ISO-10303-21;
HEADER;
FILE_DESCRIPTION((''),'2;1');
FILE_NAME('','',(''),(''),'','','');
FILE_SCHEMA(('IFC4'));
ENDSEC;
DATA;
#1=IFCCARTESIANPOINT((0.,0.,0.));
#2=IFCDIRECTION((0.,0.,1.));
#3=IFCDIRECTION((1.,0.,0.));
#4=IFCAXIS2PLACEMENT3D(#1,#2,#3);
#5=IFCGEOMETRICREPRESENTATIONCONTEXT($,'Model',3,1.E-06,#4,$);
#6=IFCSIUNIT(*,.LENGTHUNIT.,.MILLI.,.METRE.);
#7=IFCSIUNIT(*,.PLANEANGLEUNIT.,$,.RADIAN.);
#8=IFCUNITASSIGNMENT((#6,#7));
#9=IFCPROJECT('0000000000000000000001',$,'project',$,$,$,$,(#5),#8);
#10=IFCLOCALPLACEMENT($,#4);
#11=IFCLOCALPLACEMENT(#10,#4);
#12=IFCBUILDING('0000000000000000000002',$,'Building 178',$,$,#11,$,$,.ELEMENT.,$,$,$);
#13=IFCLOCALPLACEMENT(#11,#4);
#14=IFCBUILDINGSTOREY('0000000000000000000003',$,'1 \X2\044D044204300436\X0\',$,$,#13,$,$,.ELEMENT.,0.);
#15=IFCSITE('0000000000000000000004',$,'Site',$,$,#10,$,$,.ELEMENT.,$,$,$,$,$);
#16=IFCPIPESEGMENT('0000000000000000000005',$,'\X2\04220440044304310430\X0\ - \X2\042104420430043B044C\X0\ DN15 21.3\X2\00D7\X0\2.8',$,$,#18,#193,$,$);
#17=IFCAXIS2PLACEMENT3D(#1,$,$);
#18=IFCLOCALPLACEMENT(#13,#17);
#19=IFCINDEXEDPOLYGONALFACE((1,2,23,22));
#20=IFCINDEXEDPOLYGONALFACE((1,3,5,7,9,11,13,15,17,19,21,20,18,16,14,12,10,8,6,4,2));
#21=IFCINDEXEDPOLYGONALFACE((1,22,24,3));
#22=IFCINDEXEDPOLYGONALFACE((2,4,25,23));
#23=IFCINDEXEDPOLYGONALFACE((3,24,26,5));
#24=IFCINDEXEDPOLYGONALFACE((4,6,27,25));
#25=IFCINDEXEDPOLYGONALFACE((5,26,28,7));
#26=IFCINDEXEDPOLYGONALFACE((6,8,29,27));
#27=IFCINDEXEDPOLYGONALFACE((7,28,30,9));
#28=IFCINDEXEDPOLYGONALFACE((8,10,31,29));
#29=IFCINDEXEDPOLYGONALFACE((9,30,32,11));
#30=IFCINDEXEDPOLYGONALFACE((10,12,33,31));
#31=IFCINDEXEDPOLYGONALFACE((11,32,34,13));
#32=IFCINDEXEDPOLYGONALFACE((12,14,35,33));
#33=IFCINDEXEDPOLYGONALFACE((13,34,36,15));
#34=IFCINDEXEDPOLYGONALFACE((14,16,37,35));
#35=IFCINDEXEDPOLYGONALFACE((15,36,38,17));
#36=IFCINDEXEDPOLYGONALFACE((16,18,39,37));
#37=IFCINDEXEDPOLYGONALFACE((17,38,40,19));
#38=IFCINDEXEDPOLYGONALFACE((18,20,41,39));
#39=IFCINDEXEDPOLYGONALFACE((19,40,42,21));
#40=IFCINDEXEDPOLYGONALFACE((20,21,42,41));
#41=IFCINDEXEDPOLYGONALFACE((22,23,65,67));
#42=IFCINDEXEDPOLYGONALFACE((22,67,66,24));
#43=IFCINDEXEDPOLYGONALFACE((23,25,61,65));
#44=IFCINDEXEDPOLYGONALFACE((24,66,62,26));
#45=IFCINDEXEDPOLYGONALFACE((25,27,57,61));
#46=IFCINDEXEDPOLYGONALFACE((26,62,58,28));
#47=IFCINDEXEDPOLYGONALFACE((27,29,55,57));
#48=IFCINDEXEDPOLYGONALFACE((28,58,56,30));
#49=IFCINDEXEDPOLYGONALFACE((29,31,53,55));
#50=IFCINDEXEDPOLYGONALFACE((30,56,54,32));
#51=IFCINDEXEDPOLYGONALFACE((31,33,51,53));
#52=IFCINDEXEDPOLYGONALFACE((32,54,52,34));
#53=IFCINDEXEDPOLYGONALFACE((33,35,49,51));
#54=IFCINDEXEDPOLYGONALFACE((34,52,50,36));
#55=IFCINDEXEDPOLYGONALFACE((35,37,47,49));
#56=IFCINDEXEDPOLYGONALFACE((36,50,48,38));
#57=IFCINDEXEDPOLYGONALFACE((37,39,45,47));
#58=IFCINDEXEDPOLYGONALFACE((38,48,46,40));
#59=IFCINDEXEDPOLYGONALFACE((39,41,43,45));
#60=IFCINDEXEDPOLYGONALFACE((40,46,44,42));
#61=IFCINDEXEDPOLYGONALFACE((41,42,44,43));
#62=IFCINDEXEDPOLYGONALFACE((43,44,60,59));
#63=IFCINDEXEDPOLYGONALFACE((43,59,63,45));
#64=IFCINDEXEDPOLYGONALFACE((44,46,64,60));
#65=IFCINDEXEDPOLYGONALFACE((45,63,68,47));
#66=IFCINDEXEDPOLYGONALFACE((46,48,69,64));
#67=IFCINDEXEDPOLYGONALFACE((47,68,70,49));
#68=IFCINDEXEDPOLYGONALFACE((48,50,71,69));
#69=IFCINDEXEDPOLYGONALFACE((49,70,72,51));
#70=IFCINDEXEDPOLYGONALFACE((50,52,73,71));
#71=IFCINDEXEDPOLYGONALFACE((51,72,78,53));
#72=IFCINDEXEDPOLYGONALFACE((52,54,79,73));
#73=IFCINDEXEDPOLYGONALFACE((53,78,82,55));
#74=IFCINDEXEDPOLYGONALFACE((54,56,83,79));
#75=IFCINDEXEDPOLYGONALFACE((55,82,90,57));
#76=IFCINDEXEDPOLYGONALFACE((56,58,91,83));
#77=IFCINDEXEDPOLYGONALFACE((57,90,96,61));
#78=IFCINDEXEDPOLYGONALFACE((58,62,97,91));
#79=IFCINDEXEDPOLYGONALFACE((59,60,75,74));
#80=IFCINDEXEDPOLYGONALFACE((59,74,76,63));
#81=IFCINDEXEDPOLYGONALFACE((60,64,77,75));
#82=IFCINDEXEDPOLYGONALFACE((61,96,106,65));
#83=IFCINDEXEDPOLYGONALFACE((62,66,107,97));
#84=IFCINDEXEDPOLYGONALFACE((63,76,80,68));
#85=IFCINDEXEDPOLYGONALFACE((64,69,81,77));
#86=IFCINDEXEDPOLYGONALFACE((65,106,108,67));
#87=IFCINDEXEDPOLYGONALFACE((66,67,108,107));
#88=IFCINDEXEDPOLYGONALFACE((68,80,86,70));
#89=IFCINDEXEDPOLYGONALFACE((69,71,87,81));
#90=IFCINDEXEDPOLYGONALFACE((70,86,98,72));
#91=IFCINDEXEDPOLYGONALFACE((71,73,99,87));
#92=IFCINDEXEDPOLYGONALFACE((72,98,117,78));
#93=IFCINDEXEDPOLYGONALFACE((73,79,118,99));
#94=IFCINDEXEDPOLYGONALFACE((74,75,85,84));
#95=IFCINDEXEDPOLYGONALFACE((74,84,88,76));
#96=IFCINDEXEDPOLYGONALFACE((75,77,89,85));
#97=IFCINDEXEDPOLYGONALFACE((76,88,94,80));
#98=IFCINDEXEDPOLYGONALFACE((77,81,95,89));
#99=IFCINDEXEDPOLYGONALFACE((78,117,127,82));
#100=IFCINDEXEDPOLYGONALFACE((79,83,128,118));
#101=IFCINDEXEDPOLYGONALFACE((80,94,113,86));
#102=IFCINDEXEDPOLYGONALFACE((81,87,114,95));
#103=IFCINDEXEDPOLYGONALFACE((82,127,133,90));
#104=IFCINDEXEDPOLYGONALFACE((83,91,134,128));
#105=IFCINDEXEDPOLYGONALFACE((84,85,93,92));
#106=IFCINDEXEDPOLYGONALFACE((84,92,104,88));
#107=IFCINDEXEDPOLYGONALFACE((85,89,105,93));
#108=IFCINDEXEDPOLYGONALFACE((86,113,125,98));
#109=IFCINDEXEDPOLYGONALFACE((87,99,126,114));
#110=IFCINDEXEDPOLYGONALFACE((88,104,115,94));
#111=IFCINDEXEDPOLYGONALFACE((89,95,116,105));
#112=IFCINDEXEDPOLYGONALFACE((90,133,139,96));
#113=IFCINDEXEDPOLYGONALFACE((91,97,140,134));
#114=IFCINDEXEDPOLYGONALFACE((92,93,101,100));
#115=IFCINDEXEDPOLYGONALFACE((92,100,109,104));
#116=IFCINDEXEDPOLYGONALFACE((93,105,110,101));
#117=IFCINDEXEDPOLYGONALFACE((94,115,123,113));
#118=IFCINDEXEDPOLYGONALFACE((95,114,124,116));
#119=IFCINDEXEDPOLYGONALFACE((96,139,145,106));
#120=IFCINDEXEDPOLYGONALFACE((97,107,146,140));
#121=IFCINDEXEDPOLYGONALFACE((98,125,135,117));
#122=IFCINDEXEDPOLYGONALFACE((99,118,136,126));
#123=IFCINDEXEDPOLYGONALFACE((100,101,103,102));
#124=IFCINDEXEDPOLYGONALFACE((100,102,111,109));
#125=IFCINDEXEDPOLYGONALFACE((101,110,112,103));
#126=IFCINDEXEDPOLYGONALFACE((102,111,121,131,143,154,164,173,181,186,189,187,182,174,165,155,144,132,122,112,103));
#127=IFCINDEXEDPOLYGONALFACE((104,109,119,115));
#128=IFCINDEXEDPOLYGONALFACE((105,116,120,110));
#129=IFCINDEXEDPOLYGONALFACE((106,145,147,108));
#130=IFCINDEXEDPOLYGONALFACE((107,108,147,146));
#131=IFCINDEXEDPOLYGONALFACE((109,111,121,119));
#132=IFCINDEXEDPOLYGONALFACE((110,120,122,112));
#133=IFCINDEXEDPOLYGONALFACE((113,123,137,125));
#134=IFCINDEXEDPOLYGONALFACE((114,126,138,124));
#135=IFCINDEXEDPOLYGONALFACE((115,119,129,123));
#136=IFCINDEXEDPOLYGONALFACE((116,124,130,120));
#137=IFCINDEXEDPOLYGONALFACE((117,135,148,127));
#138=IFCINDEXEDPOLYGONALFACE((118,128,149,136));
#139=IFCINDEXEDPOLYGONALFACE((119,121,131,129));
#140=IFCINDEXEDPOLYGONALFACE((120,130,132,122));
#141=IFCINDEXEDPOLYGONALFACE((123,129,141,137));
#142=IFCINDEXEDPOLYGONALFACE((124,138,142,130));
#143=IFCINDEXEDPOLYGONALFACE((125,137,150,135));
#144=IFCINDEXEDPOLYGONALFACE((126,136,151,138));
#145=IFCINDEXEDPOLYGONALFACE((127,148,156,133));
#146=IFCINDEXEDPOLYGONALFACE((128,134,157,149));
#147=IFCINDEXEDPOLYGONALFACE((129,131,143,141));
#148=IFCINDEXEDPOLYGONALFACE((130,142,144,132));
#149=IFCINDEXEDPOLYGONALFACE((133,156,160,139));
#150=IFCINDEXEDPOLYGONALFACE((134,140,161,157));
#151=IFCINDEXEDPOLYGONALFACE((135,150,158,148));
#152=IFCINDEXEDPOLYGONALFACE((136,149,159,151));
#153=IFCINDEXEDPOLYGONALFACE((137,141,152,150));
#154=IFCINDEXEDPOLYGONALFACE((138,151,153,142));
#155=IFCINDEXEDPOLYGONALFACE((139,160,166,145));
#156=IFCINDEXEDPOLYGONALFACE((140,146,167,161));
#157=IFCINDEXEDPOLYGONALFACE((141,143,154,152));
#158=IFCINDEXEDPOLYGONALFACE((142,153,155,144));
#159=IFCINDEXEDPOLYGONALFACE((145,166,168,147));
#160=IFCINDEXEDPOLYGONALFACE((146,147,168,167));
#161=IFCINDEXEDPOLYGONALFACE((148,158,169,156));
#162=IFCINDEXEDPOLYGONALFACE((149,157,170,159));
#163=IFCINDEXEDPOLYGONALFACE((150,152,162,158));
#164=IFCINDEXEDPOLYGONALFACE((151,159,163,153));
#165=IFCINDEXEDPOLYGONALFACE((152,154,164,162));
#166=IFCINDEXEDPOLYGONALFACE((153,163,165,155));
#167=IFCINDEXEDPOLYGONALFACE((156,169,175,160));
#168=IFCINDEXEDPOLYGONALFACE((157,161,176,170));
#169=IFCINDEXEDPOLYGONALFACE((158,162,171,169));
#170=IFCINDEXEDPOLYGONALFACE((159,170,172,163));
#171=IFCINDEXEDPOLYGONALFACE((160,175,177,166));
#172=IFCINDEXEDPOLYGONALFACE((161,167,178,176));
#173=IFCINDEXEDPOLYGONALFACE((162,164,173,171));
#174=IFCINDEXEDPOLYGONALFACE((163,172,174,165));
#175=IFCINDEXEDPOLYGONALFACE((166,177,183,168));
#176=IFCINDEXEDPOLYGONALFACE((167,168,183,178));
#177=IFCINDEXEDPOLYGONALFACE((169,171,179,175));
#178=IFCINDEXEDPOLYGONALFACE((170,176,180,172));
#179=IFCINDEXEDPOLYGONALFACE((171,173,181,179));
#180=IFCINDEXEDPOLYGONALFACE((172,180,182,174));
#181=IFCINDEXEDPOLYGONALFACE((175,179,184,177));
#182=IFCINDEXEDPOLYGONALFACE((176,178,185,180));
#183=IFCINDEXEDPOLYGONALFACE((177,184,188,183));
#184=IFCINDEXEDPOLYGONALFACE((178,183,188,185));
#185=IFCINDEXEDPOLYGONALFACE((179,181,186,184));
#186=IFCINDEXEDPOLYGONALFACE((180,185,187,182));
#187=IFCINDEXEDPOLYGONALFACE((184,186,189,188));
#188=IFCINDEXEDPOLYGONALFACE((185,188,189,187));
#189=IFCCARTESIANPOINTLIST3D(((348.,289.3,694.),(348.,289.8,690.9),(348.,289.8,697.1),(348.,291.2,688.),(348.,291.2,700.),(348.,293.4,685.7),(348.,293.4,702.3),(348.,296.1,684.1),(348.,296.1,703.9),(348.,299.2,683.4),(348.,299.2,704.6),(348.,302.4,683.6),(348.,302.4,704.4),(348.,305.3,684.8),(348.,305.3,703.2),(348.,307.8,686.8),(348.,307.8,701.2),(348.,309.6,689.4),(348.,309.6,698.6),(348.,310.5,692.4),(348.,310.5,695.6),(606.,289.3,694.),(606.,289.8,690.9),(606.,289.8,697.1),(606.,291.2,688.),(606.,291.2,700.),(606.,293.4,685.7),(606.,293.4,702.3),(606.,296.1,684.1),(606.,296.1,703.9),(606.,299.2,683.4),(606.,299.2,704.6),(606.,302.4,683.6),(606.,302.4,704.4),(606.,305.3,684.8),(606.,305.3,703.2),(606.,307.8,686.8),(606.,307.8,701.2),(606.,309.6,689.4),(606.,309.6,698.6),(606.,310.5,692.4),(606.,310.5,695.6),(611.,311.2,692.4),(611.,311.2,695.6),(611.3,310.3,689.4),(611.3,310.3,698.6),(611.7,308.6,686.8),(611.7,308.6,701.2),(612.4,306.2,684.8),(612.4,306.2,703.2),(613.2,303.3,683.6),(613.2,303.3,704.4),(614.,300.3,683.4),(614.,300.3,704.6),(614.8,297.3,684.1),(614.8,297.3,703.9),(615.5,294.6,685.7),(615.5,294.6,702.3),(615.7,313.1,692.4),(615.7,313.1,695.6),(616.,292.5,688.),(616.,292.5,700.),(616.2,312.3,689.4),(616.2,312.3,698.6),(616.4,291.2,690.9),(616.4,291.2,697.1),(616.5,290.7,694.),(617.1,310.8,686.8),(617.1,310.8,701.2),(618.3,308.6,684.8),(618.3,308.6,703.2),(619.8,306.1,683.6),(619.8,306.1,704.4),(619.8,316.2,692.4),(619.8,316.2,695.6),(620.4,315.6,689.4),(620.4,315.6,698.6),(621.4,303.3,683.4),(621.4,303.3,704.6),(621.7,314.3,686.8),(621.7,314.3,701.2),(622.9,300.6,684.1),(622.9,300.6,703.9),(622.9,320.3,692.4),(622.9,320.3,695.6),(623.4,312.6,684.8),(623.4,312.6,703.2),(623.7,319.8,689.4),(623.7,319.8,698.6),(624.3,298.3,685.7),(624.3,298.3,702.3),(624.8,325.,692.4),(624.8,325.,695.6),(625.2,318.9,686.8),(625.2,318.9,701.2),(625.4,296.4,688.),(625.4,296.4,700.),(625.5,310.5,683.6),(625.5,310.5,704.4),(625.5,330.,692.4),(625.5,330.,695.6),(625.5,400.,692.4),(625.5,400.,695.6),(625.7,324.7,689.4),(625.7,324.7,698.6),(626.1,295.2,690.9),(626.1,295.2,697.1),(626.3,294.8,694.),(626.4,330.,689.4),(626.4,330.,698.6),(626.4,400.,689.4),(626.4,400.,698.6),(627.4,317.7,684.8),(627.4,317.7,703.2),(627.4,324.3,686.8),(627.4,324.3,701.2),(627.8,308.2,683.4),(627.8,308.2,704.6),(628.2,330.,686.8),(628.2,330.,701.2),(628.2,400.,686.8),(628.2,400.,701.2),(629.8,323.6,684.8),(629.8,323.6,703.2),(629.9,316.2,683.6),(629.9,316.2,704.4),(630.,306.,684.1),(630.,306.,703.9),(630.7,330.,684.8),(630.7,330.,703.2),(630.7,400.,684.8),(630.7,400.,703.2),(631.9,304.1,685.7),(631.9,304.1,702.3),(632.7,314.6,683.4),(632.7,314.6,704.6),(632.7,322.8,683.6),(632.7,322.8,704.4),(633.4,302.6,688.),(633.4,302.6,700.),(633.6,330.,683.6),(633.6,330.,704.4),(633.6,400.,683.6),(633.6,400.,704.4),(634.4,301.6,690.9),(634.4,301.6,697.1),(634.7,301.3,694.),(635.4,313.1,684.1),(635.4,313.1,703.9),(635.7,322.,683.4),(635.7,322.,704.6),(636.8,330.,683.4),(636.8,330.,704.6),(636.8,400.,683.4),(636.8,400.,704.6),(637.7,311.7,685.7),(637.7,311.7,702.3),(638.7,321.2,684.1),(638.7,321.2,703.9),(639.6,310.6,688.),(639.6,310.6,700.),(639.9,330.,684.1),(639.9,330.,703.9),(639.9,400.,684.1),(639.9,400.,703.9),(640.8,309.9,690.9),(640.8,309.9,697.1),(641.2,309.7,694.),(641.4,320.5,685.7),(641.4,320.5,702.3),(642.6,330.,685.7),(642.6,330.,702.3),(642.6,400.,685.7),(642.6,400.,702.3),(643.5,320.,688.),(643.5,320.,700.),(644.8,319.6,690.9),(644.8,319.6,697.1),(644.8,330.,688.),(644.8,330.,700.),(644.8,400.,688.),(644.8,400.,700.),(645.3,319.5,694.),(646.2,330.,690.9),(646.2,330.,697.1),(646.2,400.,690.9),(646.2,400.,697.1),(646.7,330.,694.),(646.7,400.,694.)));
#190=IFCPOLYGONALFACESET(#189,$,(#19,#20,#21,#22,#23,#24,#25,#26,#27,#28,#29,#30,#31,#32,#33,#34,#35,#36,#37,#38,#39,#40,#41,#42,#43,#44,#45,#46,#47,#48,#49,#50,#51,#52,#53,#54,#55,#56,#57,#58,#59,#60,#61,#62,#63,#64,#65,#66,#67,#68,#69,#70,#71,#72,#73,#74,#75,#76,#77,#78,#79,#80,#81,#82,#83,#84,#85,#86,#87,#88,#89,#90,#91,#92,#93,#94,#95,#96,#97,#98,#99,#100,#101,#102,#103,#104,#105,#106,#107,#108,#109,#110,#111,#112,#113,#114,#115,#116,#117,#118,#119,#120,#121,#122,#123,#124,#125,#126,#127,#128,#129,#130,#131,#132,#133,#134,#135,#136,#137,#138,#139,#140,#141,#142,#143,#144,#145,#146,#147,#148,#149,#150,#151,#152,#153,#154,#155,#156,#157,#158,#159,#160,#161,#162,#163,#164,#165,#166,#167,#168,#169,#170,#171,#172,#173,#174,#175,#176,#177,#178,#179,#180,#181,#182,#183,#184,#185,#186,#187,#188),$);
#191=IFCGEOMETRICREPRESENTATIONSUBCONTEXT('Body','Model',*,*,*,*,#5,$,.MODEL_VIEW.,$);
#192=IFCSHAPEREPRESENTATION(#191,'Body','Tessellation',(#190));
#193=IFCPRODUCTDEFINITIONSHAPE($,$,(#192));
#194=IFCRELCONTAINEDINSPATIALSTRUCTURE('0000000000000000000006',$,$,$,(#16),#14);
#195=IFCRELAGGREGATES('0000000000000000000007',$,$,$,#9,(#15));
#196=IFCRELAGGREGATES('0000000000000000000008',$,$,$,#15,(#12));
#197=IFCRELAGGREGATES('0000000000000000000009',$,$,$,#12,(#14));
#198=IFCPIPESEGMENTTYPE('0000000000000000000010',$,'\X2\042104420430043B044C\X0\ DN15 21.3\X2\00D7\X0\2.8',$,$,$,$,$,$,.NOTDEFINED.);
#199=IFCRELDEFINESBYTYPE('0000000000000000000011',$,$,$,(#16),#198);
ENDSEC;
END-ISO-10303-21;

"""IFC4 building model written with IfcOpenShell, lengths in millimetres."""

from ifc_helpers import new_model, entity, si_unit, frame, origin_with_axes, place, context, subcontext, project, spatial, source, transform, mapped, type_object, element, save


model = new_model("IFC4")

# Units and contexts
model_context = context("Model", 3, precision=1e-06, world=origin_with_axes())
body_context = subcontext(model_context, "Body", "Model", "MODEL_VIEW")
ifc_project = project(units=[si_unit("LENGTHUNIT", "METRE", prefix="MILLI"), si_unit("PLANEANGLEUNIT", "RADIAN")], contexts=[model_context])

# Site, building, storey
site_placement = place(None, origin_with_axes())
site = spatial("IfcSite", under=ifc_project, at=site_placement, Name="Site", CompositionType="ELEMENT")
building_placement = place(site_placement, origin_with_axes())
building = spatial("IfcBuilding", under=site, at=building_placement, Name="Building 178", CompositionType="ELEMENT")
storey_placement = place(building_placement, origin_with_axes())
storey = spatial("IfcBuildingStorey", under=building, at=storey_placement, Name="1 этаж", CompositionType="ELEMENT", Elevation=0.0)

# Pipe segment
pipe_segment_type = type_object("IfcPipeSegmentType", Name="Сталь DN15 21.3×2.8", PredefinedType="NOTDEFINED")
shared_shape_1 = source(origin_with_axes(), body_context, "Body", "AdvancedSweptSolid", [
    entity("IfcSweptDiskSolid", entity("IfcIndexedPolyCurve", entity("IfcCartesianPointList3D", [[0.0, 0.0, 0.0], [0.0, 0.0, -70.0], [8.8, 0.0, -91.2], [30.0, 0.0, -100.0], [288.0, 0.0, -100.0]]), [entity("IfcLineIndex", [1, 2]), entity("IfcArcIndex", [2, 3, 4]), entity("IfcLineIndex", [4, 5])]), 10.7),
])
for number, where, z_axis, x_axis, name in (
    (1, (636.0, 400.0, 694.0), (0.0, 1.0, 0.0), (-1.0, 0.0, 0.0), "Труба - Сталь DN15 21.3×2.8"),
):
    element("IfcPipeSegment", number, at=place(storey_placement, frame(where, z_axis=z_axis, x_axis=x_axis)), inside=storey, type_object=pipe_segment_type, Name=name, context=body_context, shape_type="MappedRepresentation", body=[
        mapped(shared_shape_1, transform((0.0, 0.0, 0.0), x_axis=(1.0, 0.0, 0.0), y_axis=(0.0, 1.0, 0.0), z_axis=(0.0, 0.0, 1.0), scale=1.0)),
    ])

save(model, "model.ifc")
